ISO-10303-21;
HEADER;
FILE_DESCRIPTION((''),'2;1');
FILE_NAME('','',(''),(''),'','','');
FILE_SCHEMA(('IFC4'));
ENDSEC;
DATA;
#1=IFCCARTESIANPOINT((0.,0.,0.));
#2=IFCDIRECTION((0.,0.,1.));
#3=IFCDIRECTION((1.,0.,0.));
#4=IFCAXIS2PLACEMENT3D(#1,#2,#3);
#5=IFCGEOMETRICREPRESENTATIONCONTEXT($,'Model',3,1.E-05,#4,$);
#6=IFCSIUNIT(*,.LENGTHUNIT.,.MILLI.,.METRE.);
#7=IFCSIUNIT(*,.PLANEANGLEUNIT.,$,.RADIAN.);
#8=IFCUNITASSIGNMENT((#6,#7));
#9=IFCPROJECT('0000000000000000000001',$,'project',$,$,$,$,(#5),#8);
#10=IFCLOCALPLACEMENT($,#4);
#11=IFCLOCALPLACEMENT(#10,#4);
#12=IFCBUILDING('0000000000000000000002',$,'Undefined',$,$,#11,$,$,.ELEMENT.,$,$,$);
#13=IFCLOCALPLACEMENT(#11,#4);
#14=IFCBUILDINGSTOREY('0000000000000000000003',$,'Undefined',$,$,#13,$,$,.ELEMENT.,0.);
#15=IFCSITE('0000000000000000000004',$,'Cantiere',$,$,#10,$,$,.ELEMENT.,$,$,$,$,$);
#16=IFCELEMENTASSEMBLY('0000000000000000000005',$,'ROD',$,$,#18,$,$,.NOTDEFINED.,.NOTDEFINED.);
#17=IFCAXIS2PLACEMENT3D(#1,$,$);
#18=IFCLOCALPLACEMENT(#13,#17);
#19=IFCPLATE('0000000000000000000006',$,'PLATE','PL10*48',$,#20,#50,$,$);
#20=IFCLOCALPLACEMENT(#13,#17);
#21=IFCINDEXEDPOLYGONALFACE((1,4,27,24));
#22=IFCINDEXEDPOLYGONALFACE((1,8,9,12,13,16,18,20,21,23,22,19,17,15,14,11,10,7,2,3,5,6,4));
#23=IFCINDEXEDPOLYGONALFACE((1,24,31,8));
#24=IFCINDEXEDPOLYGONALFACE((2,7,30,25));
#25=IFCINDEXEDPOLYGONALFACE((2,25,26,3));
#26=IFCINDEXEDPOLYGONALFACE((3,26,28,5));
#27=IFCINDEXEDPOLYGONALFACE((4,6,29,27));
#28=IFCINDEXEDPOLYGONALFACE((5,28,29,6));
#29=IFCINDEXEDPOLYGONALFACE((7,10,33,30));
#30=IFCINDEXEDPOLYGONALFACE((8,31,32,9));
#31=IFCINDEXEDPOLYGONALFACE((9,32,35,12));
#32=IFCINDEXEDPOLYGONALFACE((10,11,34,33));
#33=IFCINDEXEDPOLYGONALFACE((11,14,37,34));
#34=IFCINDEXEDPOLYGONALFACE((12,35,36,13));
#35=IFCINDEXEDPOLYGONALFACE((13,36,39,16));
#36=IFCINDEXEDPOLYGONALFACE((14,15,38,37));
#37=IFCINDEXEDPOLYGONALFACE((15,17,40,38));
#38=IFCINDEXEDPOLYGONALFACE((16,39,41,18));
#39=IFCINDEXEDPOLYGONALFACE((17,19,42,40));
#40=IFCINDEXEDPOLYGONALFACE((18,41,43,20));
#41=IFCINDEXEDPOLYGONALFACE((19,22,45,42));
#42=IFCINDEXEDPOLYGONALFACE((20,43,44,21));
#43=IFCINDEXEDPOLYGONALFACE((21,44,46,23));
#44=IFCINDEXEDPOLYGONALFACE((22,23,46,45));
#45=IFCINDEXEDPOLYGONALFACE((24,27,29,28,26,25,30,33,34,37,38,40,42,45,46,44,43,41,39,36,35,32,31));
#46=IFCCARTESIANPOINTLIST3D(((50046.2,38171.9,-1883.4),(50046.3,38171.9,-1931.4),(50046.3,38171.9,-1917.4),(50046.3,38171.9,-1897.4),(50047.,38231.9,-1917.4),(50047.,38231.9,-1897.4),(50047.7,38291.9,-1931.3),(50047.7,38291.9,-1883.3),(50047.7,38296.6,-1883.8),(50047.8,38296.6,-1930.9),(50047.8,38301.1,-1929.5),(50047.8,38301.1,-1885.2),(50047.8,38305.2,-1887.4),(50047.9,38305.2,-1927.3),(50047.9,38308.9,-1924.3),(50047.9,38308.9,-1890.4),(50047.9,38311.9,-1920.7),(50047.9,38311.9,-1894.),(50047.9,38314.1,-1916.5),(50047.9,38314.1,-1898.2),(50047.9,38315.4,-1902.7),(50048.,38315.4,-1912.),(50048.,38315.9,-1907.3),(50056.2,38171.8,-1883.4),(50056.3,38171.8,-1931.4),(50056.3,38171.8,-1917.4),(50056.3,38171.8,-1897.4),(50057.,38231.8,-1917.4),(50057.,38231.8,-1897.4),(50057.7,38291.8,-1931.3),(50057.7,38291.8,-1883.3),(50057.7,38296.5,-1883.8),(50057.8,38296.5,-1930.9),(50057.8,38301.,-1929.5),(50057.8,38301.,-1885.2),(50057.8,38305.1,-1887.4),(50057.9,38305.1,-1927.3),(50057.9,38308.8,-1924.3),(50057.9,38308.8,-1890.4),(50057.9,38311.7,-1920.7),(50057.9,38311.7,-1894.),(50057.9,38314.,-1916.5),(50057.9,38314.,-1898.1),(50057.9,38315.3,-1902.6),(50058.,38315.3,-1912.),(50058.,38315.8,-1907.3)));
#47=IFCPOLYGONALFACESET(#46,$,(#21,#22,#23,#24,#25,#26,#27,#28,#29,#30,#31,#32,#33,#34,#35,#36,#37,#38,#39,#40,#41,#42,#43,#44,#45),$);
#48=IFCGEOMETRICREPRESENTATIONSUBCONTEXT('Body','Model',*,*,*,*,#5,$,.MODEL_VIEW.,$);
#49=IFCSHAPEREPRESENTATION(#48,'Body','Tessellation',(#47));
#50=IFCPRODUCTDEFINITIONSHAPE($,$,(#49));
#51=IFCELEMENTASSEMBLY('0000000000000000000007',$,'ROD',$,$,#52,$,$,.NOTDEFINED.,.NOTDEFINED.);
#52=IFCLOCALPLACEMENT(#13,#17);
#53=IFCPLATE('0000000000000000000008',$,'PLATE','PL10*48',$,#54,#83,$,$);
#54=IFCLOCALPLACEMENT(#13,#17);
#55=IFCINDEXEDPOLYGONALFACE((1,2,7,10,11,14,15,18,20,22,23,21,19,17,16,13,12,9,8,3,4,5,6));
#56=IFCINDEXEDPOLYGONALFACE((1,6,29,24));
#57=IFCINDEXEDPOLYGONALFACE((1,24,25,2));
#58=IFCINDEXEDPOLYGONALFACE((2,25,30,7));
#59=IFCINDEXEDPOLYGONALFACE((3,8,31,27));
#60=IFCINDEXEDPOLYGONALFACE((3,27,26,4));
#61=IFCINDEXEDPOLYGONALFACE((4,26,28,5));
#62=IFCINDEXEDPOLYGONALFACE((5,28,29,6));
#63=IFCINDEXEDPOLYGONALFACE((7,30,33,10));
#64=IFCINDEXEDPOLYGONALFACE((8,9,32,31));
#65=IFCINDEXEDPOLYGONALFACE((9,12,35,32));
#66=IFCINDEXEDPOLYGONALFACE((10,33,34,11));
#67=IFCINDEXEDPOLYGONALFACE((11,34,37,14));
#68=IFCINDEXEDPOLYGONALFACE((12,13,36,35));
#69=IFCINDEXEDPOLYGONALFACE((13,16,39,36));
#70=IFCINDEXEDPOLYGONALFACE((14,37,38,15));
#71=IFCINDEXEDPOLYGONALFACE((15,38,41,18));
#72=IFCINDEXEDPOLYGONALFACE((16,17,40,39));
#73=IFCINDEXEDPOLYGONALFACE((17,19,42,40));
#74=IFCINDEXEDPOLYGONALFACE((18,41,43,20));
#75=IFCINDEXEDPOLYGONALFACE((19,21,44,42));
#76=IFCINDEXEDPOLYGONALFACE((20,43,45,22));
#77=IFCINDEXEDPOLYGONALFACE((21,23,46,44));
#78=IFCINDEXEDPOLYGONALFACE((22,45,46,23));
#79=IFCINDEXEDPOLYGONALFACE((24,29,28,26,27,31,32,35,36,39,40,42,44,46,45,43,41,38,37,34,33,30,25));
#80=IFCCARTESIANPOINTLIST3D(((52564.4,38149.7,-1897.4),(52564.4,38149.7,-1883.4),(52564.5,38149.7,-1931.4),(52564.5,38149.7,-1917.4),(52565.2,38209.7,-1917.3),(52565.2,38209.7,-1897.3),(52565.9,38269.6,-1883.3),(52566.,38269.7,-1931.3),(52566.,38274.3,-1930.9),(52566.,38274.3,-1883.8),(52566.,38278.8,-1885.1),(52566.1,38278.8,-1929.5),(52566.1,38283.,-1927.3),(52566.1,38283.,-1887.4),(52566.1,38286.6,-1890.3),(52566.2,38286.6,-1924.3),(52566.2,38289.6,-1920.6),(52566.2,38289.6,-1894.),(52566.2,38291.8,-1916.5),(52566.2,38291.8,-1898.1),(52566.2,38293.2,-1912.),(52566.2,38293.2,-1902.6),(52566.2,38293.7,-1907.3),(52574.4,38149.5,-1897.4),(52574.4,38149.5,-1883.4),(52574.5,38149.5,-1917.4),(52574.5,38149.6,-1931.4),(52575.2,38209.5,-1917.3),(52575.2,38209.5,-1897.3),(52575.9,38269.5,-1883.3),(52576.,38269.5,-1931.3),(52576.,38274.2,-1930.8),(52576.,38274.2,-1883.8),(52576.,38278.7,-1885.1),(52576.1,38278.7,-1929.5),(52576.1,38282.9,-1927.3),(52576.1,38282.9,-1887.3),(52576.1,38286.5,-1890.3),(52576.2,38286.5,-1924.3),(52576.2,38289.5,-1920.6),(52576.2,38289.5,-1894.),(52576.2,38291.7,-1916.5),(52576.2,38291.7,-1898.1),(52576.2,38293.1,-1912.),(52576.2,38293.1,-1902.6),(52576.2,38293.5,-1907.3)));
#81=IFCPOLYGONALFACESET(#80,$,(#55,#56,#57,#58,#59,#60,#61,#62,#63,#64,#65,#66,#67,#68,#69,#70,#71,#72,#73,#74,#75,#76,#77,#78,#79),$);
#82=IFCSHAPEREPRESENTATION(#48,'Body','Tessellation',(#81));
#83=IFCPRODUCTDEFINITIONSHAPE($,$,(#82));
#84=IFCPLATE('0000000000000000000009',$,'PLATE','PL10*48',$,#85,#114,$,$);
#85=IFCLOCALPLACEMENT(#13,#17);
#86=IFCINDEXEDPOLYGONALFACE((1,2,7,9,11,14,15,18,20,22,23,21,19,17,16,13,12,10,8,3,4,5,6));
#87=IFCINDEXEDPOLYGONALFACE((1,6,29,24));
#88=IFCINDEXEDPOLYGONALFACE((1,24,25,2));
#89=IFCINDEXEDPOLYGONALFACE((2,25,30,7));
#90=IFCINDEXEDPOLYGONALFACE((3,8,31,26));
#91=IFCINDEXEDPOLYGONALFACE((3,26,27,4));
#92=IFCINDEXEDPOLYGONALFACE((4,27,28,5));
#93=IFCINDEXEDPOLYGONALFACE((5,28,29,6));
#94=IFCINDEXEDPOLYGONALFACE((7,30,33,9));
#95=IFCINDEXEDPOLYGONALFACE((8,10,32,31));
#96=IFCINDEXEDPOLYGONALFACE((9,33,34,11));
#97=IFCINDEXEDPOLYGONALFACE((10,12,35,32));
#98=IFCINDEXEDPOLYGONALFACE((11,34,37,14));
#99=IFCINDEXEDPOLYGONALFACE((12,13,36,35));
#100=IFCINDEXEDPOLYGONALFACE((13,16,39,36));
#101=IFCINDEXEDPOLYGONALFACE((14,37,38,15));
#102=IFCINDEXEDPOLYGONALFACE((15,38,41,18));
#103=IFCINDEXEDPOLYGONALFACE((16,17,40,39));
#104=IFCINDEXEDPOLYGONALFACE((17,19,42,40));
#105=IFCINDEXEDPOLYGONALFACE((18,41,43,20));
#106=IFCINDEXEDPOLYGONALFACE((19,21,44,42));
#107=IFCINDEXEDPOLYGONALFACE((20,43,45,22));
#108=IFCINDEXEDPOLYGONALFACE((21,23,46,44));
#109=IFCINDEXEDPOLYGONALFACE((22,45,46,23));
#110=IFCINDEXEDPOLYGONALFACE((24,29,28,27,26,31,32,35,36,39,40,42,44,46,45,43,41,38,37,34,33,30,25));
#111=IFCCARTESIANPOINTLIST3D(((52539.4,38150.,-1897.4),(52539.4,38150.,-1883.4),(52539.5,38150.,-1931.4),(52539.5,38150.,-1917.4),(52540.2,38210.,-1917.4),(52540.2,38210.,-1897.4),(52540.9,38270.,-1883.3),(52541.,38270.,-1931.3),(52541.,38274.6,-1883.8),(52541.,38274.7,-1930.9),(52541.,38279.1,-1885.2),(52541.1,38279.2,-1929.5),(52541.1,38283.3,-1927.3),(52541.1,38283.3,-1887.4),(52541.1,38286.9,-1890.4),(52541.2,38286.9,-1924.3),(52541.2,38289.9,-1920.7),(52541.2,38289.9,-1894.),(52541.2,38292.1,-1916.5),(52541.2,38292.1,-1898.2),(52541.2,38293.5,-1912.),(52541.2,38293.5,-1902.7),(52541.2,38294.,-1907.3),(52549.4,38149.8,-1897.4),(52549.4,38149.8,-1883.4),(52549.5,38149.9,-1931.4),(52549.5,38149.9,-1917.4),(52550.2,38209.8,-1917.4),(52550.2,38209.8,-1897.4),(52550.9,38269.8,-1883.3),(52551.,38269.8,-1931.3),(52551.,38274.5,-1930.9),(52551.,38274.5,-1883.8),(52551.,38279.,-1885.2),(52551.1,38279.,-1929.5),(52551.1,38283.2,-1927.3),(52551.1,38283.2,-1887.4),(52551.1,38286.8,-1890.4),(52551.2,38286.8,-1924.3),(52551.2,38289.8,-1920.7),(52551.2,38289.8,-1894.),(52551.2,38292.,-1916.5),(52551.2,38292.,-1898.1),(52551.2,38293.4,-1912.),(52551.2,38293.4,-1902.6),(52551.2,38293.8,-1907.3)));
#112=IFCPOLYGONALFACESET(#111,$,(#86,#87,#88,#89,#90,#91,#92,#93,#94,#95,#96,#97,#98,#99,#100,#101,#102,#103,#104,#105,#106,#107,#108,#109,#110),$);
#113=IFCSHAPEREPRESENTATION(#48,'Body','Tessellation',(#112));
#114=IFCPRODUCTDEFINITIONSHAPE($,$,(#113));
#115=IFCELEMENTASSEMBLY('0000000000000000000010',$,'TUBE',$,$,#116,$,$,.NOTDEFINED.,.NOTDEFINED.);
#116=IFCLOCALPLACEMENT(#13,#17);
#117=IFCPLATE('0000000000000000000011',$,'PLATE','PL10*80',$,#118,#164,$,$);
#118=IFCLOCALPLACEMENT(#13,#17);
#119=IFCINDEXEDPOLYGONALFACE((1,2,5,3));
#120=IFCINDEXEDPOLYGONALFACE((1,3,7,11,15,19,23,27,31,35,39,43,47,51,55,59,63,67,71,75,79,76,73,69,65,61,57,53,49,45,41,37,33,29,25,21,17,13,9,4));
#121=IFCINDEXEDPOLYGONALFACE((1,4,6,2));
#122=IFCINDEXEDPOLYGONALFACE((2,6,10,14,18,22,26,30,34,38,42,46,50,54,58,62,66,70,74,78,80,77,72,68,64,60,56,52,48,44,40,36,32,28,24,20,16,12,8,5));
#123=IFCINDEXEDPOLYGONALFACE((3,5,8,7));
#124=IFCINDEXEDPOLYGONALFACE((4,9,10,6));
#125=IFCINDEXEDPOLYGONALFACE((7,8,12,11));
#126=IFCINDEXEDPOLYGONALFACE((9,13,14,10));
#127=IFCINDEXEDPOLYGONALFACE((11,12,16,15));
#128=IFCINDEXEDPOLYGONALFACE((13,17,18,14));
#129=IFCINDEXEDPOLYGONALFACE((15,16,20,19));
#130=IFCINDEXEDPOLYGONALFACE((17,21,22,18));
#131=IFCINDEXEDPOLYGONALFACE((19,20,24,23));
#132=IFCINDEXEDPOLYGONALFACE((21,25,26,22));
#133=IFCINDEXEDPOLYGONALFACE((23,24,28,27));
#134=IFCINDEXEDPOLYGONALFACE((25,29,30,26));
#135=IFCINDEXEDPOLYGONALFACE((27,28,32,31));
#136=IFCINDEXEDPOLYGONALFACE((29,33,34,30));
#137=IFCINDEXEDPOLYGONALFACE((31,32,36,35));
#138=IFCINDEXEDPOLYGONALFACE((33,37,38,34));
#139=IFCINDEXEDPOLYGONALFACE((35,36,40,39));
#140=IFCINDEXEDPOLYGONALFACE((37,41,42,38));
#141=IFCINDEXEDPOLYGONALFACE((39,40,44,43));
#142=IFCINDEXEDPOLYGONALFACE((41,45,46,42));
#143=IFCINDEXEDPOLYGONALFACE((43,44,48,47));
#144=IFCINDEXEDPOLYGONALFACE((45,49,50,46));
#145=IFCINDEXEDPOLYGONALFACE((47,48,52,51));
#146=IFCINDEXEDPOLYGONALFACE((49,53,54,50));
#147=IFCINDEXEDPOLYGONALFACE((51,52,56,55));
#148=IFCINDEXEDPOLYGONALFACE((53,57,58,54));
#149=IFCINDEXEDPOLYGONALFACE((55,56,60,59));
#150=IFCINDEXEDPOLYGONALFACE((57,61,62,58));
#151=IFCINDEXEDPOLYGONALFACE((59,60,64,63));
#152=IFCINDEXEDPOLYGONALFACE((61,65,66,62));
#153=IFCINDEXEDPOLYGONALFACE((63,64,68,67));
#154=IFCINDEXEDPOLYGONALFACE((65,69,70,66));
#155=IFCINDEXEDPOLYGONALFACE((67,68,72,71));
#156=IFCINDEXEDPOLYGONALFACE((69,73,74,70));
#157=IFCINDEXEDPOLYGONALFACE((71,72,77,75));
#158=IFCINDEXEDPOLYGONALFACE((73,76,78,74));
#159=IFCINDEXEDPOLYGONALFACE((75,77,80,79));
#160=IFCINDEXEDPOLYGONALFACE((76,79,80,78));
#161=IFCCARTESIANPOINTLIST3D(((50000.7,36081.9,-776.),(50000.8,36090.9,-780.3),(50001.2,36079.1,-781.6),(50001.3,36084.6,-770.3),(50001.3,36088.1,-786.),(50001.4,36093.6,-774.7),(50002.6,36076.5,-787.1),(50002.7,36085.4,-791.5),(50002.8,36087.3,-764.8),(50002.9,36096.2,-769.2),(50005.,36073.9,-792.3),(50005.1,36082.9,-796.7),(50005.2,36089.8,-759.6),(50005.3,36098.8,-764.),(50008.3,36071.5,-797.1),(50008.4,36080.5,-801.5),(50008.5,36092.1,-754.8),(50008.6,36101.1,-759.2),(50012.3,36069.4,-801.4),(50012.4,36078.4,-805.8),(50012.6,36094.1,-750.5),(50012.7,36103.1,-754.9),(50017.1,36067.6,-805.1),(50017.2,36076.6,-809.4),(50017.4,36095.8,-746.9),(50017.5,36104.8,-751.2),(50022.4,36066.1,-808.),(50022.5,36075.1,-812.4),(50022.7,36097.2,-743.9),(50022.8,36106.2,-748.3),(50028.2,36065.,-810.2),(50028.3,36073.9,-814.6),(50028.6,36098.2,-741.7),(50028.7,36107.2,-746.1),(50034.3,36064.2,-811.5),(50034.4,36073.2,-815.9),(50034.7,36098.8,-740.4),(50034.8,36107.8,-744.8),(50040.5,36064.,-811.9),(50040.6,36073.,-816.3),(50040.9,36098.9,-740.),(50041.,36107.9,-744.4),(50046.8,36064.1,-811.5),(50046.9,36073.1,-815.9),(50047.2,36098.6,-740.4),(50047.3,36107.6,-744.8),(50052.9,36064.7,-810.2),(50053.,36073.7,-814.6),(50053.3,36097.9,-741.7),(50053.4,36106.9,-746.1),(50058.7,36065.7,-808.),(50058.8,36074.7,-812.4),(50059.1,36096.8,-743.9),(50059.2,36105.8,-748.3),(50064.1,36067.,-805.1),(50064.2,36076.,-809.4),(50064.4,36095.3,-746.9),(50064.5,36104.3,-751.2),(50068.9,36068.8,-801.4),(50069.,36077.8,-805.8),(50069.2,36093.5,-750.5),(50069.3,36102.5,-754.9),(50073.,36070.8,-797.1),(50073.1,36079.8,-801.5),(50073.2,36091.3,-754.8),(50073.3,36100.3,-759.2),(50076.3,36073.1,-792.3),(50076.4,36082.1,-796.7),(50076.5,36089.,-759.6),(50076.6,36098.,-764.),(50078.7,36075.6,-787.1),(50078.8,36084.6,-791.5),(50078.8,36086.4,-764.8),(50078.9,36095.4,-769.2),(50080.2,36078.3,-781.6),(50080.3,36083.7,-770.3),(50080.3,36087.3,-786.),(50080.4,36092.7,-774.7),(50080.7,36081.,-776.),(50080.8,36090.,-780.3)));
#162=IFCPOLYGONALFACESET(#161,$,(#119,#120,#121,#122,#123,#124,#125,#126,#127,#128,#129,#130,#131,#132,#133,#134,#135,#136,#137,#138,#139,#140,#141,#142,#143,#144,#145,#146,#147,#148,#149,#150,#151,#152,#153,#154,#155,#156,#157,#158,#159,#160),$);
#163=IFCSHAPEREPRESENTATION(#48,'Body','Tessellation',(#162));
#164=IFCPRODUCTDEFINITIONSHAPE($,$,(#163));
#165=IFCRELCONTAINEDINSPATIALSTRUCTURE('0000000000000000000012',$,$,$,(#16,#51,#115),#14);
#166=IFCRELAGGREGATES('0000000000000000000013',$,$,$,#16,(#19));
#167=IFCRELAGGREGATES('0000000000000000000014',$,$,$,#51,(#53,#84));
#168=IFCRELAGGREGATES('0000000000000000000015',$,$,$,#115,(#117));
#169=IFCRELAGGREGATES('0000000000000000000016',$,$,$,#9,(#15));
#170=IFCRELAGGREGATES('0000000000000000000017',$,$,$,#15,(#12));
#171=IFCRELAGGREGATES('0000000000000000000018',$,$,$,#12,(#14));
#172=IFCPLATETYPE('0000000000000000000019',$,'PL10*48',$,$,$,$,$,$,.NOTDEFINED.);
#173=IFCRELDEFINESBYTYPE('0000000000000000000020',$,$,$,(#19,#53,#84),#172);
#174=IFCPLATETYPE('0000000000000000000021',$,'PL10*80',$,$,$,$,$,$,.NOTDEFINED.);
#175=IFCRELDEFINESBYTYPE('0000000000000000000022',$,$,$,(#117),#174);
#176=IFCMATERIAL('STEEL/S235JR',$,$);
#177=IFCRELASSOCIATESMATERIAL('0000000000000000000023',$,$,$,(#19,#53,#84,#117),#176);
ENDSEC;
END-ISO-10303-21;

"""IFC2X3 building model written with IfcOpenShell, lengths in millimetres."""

from ifc_helpers import new_model, si_unit, frame, origin_with_axes, place, context, subcontext, project, spatial, polyline, outline, extrude, material, type_object, element, aggregate, save


model = new_model("IFC2X3")

# Units and contexts
model_context = context("Model", 3, precision=1e-05, world=origin_with_axes())
body_context = subcontext(model_context, "Body", "Model", "MODEL_VIEW")
ifc_project = project(units=[si_unit("LENGTHUNIT", "METRE", prefix="MILLI"), si_unit("PLANEANGLEUNIT", "RADIAN")], contexts=[model_context])

# Site, building, storey
site_placement = place(None, origin_with_axes())
site = spatial("IfcSite", under=ifc_project, at=site_placement, Name="Cantiere", CompositionType="ELEMENT")
building_placement = place(site_placement, origin_with_axes())
building = spatial("IfcBuilding", under=site, at=building_placement, Name="Undefined", CompositionType="ELEMENT")
storey_placement = place(building_placement, origin_with_axes())
storey = spatial("IfcBuildingStorey", under=building, at=storey_placement, Name="Undefined", CompositionType="ELEMENT", Elevation=0.0)

# Shared definitions
ifc_material_1 = material(Name="STEEL/S235JR")

# Element assemblies, plates
assembly_1_placement = place(storey_placement, origin_with_axes())
assembly_1 = element("IfcElementAssembly", 1, at=assembly_1_placement, inside=storey, Name="ROD", AssemblyPlace="NOTDEFINED", PredefinedType="NOTDEFINED")
plate_type_1 = type_object("IfcPlateType", Name="PL10*48", PredefinedType="NOTDEFINED")
plate_1_placement = place(assembly_1_placement, frame((50051.3, 38171.9, -1931.4), z_axis=(0.999931, -0.011737, 0.001062), x_axis=(0.011737, 0.999931, 0.000382)))
plate_1 = element("IfcPlate", 2, at=plate_1_placement, type_object=plate_type_1, material=ifc_material_1, Name="PLATE", Description="PL10*48", context=body_context, shape_type="SweptSolid", body=[
    extrude(outline(polyline([(0.0, 0.0), (120.0, 0.0), (124.7, 0.5), (129.2, 1.8), (133.3, 4.0), (137.0, 7.0), (140.0, 10.7), (142.2, 14.8), (143.5, 19.3), (144.0, 24.0), (144.0, 24.0), (143.5, 28.7), (142.2, 33.2), (140.0, 37.3), (137.0, 41.0), (133.3, 44.0), (129.2, 46.2), (124.7, 47.5), (120.0, 48.0), (0.0, 48.0), (0.0, 34.0), (60.0, 34.0), (60.0, 14.0), (0.0, 14.0), (0.0, 0.0)])), frame((0.0, 0.0, -5.0), z_axis=(0.0, 0.0, 1.0), x_axis=(1.0, 0.0, 0.0)), (0.0, 0.0, 1.0), 10.0),
])
aggregate(assembly_1, [plate_1])
assembly_2_placement = place(storey_placement, origin_with_axes())
assembly_2 = element("IfcElementAssembly", 3, at=assembly_2_placement, inside=storey, Name="ROD", AssemblyPlace="NOTDEFINED", PredefinedType="NOTDEFINED")
plate_2_placement = place(assembly_2_placement, frame((52569.5, 38149.6, -1931.4), z_axis=(0.999924, -0.012292, 0.001062), x_axis=(0.012291, 0.999924, 0.000382)))
plate_2 = element("IfcPlate", 4, at=plate_2_placement, type_object=plate_type_1, material=ifc_material_1, Name="PLATE", Description="PL10*48", context=body_context, shape_type="SweptSolid", body=[
    extrude(outline(polyline([(0.0, 0.0), (120.0, 0.0), (124.7, 0.5), (129.2, 1.8), (133.3, 4.0), (137.0, 7.0), (140.0, 10.7), (142.2, 14.8), (143.5, 19.3), (144.0, 24.0), (144.0, 24.0), (143.5, 28.7), (142.2, 33.2), (140.0, 37.3), (137.0, 41.0), (133.3, 44.0), (129.2, 46.2), (124.7, 47.5), (120.0, 48.0), (0.0, 48.0), (0.0, 34.0), (60.0, 34.0), (60.0, 14.0), (0.0, 14.0), (0.0, 0.0)])), frame((0.0, 0.0, -5.0), z_axis=(0.0, 0.0, 1.0), x_axis=(1.0, 0.0, 0.0)), (0.0, 0.0, 1.0), 10.0),
])
plate_3_placement = place(assembly_2_placement, frame((52544.5, 38149.9, -1931.4), z_axis=(0.999924, -0.012292, 0.001062), x_axis=(0.012291, 0.999924, 0.000382)))
plate_3 = element("IfcPlate", 5, at=plate_3_placement, type_object=plate_type_1, material=ifc_material_1, Name="PLATE", Description="PL10*48", context=body_context, shape_type="SweptSolid", body=[
    extrude(outline(polyline([(0.0, 0.0), (120.0, 0.0), (124.7, 0.5), (129.2, 1.8), (133.3, 4.0), (137.0, 7.0), (140.0, 10.7), (142.2, 14.8), (143.5, 19.3), (144.0, 24.0), (144.0, 24.0), (143.5, 28.7), (142.2, 33.2), (140.0, 37.3), (137.0, 41.0), (133.3, 44.0), (129.2, 46.2), (124.7, 47.5), (120.0, 48.0), (0.0, 48.0), (0.0, 34.0), (60.0, 34.0), (60.0, 14.0), (0.0, 14.0), (0.0, 0.0)])), frame((0.0, 0.0, -5.0), z_axis=(0.0, 0.0, 1.0), x_axis=(1.0, 0.0, 0.0)), (0.0, 0.0, 1.0), 10.0),
])
aggregate(assembly_2, [plate_2, plate_3])

# Element assembly, plate
assembly_3_placement = place(storey_placement, origin_with_axes())
assembly_3 = element("IfcElementAssembly", 6, at=assembly_3_placement, inside=storey, Name="TUBE", AssemblyPlace="NOTDEFINED", PredefinedType="NOTDEFINED")
plate_type_2 = type_object("IfcPlateType", Name="PL10*80", PredefinedType="NOTDEFINED")
plate_4_placement = place(assembly_3_placement, frame((50001.0, 36103.8, -742.2), z_axis=(-0.009893, -0.899493, 0.436823), x_axis=(-0.004811, -0.436796, -0.899548)))
plate_4 = element("IfcPlate", 7, at=plate_4_placement, type_object=plate_type_2, material=ifc_material_1, Name="PLATE", Description="PL10*80", context=body_context, shape_type="SweptSolid", body=[
    extrude(outline(polyline([(0.0, 40.0), (0.5, 33.7), (2.0, 27.6), (4.4, 21.8), (7.6, 16.5), (11.7, 11.7), (16.5, 7.6), (21.8, 4.4), (27.6, 2.0), (33.7, 0.5), (40.0, 0.0), (40.0, 0.0), (46.3, 0.5), (52.4, 2.0), (58.2, 4.4), (63.5, 7.6), (68.3, 11.7), (72.4, 16.5), (75.6, 21.8), (78.0, 27.6), (79.5, 33.7), (80.0, 40.0), (80.0, 40.0), (79.5, 46.3), (78.0, 52.4), (75.6, 58.2), (72.4, 63.5), (68.3, 68.3), (63.5, 72.4), (58.2, 75.6), (52.4, 78.0), (46.3, 79.5), (40.0, 80.0), (40.0, 80.0), (33.7, 79.5), (27.6, 78.0), (21.8, 75.6), (16.5, 72.4), (11.7, 68.3), (7.6, 63.5), (4.4, 58.2), (2.0, 52.4), (0.5, 46.3), (0.0, 40.0), (0.0, 40.0)])), frame((0.0, 0.0, -5.0), z_axis=(0.0, 0.0, 1.0), x_axis=(1.0, 0.0, 0.0)), (0.0, 0.0, 1.0), 10.0),
])

aggregate(assembly_3, [plate_4])

save(model, "model.ifc")
